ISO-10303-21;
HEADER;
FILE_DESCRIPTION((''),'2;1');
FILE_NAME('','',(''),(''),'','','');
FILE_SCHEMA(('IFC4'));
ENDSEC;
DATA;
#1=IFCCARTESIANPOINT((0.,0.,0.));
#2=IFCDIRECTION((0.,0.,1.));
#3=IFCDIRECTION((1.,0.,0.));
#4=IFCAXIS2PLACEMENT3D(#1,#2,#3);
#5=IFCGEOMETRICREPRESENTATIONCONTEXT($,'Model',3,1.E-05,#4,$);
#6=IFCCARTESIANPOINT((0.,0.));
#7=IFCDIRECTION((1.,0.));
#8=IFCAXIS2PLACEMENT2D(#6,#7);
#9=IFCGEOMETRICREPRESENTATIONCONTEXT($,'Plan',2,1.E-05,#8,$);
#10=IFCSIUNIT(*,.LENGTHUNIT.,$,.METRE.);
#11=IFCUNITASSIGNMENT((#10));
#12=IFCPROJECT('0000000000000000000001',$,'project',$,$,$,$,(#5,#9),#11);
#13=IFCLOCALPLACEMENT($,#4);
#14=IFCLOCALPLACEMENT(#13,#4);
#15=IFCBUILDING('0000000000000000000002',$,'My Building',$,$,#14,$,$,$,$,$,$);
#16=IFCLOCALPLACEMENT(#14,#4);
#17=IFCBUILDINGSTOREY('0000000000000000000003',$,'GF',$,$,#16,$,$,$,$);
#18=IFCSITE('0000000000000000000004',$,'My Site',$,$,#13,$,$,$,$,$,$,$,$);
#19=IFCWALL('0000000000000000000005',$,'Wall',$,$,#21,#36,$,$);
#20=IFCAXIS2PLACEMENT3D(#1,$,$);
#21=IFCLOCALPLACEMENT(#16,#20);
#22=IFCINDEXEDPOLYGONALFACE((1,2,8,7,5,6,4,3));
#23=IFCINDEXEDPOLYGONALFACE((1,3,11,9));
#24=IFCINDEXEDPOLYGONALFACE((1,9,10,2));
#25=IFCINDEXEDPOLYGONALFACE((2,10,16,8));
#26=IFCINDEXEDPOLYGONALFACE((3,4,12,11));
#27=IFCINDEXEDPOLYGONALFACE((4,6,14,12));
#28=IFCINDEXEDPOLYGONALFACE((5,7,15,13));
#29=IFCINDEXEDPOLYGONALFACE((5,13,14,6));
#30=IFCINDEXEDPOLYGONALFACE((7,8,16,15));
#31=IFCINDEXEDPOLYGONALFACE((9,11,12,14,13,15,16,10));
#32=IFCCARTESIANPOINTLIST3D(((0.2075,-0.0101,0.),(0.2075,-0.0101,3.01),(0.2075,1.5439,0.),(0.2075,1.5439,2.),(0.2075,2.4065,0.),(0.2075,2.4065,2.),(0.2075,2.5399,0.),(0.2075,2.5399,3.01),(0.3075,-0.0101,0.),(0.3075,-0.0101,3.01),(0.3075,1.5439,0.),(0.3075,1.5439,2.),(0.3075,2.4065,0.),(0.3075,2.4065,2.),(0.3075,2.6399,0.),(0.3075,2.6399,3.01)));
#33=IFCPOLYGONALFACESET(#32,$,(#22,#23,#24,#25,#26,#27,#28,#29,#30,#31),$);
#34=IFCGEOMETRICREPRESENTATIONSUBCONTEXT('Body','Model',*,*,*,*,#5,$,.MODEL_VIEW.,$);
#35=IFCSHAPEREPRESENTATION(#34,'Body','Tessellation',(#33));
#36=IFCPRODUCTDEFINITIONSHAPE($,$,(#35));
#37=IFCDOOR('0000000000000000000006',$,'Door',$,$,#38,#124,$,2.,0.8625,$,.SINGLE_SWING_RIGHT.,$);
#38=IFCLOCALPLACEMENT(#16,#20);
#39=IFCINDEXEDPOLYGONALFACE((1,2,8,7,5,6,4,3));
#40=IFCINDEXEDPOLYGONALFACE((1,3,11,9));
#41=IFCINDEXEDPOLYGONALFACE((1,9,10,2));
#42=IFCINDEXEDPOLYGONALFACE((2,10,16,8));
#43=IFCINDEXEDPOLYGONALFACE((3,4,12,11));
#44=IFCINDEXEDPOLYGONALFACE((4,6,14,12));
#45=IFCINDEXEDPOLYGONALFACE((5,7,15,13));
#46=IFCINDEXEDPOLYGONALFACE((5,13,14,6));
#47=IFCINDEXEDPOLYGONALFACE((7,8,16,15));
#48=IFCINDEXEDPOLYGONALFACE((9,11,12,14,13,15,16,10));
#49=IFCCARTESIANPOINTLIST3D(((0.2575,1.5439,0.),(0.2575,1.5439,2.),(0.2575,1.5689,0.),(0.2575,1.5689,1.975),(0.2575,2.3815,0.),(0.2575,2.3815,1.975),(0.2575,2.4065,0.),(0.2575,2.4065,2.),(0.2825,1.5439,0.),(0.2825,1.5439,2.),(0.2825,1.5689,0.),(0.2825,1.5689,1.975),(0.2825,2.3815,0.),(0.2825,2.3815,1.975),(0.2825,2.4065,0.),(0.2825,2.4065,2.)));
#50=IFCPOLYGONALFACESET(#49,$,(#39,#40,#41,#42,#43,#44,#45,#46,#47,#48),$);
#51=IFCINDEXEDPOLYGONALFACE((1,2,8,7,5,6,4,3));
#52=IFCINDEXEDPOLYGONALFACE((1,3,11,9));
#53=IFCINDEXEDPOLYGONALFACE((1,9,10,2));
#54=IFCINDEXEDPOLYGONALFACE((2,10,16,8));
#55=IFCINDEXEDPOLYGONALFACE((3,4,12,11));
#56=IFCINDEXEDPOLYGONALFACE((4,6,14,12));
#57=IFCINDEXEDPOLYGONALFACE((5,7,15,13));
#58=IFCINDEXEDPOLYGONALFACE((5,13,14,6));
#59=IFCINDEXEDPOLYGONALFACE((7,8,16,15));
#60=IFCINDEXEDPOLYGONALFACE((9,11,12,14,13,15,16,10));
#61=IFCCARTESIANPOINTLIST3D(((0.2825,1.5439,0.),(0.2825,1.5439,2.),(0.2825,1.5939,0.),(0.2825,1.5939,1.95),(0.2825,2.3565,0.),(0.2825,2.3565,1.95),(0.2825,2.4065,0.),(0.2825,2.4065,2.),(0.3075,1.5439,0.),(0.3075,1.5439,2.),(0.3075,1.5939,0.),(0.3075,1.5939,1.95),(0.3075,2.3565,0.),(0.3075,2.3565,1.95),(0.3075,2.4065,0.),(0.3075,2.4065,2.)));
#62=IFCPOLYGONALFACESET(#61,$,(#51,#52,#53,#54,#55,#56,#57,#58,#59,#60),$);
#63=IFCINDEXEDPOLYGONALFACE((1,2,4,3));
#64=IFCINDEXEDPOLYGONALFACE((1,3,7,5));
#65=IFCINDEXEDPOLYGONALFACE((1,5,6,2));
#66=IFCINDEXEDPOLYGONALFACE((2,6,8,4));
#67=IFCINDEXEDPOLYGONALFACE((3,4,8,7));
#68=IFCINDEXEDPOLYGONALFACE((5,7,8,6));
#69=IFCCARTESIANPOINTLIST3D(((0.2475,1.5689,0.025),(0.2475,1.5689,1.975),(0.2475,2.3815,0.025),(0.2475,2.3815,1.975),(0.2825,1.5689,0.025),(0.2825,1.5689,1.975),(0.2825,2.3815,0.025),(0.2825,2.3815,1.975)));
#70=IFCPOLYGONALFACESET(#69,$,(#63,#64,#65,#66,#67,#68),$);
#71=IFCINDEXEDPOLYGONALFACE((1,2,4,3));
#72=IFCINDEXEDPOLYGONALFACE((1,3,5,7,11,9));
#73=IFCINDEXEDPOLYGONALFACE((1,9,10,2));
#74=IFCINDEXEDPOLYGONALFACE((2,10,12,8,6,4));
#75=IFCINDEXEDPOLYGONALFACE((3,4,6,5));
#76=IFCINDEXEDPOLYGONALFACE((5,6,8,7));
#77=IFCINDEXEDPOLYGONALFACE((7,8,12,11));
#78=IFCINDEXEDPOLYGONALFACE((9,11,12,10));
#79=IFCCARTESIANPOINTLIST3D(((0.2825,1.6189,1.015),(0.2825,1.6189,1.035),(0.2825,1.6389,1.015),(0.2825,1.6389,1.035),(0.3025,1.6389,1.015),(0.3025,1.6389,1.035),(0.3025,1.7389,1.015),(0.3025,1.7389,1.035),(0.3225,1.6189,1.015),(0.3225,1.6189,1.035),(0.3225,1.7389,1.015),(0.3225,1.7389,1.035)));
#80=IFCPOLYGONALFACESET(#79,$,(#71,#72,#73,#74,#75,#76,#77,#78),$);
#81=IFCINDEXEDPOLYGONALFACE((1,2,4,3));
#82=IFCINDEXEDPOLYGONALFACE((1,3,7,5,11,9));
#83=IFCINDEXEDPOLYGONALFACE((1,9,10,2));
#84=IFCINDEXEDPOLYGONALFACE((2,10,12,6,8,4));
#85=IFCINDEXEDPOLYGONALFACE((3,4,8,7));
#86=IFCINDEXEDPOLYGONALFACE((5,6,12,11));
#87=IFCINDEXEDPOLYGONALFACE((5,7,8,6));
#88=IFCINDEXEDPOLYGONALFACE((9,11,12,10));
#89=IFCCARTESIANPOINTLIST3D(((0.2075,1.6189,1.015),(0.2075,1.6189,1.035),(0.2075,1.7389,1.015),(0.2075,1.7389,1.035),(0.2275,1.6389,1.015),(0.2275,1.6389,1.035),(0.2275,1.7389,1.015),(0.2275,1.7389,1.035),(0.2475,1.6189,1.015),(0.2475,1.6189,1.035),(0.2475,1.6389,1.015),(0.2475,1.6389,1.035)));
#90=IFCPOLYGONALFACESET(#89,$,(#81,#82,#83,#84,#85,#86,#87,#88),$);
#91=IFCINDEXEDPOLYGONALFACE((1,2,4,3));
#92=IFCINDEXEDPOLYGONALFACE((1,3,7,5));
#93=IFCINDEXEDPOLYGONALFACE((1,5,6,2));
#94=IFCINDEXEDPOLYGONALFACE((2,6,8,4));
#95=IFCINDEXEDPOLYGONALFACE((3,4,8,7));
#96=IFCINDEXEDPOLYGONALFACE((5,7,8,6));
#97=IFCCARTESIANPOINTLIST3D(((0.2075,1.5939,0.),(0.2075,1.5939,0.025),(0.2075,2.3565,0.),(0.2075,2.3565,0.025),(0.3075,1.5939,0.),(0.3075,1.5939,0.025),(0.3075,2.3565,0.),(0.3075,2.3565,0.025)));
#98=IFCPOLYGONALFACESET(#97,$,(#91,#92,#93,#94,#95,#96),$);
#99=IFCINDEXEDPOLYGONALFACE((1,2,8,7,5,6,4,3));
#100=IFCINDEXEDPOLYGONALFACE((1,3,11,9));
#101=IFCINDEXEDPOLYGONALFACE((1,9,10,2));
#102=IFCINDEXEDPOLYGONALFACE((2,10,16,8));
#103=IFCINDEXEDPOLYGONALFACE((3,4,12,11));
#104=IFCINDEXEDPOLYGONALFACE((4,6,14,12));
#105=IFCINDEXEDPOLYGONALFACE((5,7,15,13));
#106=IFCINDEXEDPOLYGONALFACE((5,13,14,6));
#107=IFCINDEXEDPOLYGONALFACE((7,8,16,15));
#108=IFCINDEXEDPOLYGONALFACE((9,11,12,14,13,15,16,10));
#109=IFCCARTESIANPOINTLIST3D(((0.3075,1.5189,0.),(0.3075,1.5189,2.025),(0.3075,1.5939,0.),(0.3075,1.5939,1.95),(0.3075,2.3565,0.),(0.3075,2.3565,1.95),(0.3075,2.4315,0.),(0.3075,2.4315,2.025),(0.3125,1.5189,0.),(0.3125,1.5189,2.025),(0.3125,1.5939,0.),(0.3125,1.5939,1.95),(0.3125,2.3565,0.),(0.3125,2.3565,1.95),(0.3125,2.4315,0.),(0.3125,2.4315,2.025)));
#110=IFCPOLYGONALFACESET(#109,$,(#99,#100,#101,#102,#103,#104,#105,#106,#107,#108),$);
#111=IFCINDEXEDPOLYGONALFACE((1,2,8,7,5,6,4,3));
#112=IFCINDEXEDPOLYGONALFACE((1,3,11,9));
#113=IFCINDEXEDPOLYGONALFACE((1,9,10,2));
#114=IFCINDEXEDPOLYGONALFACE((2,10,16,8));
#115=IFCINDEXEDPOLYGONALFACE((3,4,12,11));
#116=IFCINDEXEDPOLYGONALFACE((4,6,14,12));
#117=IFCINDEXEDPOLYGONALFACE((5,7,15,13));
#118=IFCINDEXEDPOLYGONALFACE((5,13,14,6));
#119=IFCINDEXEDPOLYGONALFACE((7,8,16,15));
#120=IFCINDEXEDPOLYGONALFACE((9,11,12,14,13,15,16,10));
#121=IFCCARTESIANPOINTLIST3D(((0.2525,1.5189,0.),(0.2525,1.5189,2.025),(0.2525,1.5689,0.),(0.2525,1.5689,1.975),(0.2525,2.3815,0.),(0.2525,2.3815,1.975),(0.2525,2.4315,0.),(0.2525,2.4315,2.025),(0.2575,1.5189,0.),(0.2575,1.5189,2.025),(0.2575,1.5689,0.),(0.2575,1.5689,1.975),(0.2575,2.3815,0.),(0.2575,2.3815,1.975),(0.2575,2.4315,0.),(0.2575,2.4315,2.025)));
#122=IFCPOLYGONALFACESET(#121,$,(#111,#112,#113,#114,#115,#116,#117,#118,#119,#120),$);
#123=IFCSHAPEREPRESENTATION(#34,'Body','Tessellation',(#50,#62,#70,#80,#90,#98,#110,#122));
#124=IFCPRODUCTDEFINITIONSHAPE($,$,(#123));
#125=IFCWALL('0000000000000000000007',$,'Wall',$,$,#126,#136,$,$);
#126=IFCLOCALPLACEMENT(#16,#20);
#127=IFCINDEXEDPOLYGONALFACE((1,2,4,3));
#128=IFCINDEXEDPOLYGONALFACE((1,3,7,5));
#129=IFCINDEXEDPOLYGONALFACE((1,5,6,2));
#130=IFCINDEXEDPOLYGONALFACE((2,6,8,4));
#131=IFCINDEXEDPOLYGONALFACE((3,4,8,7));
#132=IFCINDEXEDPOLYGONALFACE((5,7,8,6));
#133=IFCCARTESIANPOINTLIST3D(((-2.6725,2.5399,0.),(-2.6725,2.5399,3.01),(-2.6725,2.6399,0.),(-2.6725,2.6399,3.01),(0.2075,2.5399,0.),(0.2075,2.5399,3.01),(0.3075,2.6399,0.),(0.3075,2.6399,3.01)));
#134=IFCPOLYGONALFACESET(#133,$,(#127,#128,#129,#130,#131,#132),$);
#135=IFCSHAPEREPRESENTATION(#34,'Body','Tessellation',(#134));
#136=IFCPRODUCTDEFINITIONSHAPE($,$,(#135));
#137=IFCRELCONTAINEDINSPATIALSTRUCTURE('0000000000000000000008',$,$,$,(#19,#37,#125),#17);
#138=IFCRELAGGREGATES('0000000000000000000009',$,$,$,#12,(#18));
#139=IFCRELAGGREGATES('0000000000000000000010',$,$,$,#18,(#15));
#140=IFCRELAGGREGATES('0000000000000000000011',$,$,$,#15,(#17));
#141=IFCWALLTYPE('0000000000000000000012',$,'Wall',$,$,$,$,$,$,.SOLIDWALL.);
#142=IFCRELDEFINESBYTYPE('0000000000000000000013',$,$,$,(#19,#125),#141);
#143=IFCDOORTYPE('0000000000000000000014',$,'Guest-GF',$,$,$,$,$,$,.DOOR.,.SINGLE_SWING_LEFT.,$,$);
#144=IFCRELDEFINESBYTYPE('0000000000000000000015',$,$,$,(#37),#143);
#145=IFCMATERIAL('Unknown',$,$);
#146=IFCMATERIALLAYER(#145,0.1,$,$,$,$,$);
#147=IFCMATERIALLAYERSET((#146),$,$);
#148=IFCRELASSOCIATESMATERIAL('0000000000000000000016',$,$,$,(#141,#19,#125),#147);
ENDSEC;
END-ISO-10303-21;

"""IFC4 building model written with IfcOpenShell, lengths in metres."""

from ifc_helpers import new_model, entity, si_unit, frame, origin_with_axes, origin_2d_with_axis, place, context, subcontext, project, spatial, line, indexed_curve, outline, extrude, shape, source, transform, mapped, material, layer, layer_set, layer_usage, type_object, type_shapes, element, fill, save


model = new_model("IFC4")

# Units and contexts
model_context = context("Model", 3, precision=1e-05, world=origin_with_axes())
plan_context = context("Plan", 2, precision=1e-05, world=origin_2d_with_axis())
body_context_1 = subcontext(model_context, "Body", "Model", "MODEL_VIEW")
body_context_2 = subcontext(plan_context, "Body", "Plan", "PLAN_VIEW")
ifc_project = project(units=[si_unit("LENGTHUNIT", "METRE")], contexts=[model_context, plan_context])

# Site, building, storey
site_placement = place(None, origin_with_axes())
site = spatial("IfcSite", under=ifc_project, at=site_placement, Name="My Site")
building_placement = place(site_placement, origin_with_axes())
building = spatial("IfcBuilding", under=site, at=building_placement, Name="My Building")
storey_placement = place(building_placement, origin_with_axes())
storey = spatial("IfcBuildingStorey", under=building, at=storey_placement, Name="GF")

# Shared definitions
ifc_material_1 = material(Name="Unknown")

# Shared definitions
ifc_layer_1 = layer(ifc_material_1, 0.1)
ifc_layer_set_1 = layer_set([ifc_layer_1])
wall_type = type_object("IfcWallType", Name="Wall", PredefinedType="SOLIDWALL", material=ifc_layer_set_1)

# Wall, opening, door
ifc_layer_usage_1 = layer_usage(ifc_layer_set_1, "AXIS2", "POSITIVE", 0.0)
wall_1_placement = place(storey_placement, frame((0.3075, -0.0101, 0.0), z_axis=(0.0, 0.0, 1.0), x_axis=(0.0, 1.0, 0.0)))
wall_1 = element("IfcWall", 1, at=wall_1_placement, inside=storey, type_object=wall_type, material=ifc_layer_usage_1, Name="Wall", context=body_context_1, shape_type="SweptSolid", body=[
    extrude(outline(indexed_curve([(0.0, 0.0), (0.0, 0.1), (2.55, 0.1), (2.65, 0.0)], segments=[line(1, 2, 3, 4, 1)])), origin_with_axes(), (0.0, 0.0, 1.0), 3.01),
])
shared_shape_1 = source(origin_with_axes(), body_context_1, "Body", "SweptSolid", [
    extrude(outline(indexed_curve([(0.0, 0.0), (0.8625, 0.0), (0.8625, 2.0), (0.0, 2.0)], segments=[line(1, 2, 3, 4, 1)])), frame((0.0, -0.6, 0.0), z_axis=(0.0, -1.0, 0.0), x_axis=(1.0, 0.0, 0.0)), (0.0, 0.0, -1.0), 1.2),
])
opening_1_placement = place(wall_1_placement, frame((1.554, 0.0, 0.0), z_axis=(0.0, 0.0, 1.0), x_axis=(1.0, 0.0, 0.0)))
opening_1 = element("IfcOpeningElement", 2, at=opening_1_placement, cuts=wall_1, PredefinedType="OPENING", context=body_context_1, shape_type="MappedRepresentation", body=[
    mapped(shared_shape_1, transform((0.0, 0.0, 0.0), x_axis=(1.0, 0.0, 0.0), y_axis=(0.0, 1.0, 0.0), z_axis=(0.0, 0.0, 1.0), scale=1.0)),
])
door_type_1 = type_object("IfcDoorType", Name="Guest-GF", OperationType="SINGLE_SWING_LEFT", PredefinedType="DOOR")
shared_shape_2 = source(origin_with_axes(), body_context_1, "Body", "SweptSolid", [
    extrude(outline(indexed_curve([(0.0, 0.0), (0.0, 2.0), (0.8625, 2.0), (0.8625, 0.0), (0.8375, 0.0), (0.8375, 1.975), (0.025, 1.975), (0.025, 0.0)], segments=[line(1, 2, 3, 4, 5, 6, 7, 8, 1)])), frame((0.0, 0.025, 0.0), z_axis=(0.0, -1.0, 0.0), x_axis=(1.0, 0.0, 0.0)), (0.0, 0.0, -1.0), 0.025),
    extrude(outline(indexed_curve([(0.0, 0.0), (0.0, 2.0), (0.8625, 2.0), (0.8625, 0.0), (0.8125, 0.0), (0.8125, 1.95), (0.05, 1.95), (0.05, 0.0)], segments=[line(1, 2, 3, 4, 5, 6, 7, 8, 1)])), frame((0.0, 0.0, 0.0), z_axis=(0.0, -1.0, 0.0), x_axis=(1.0, 0.0, 0.0)), (0.0, 0.0, -1.0), 0.025),
    extrude(outline(indexed_curve([(0.0, 0.0), (0.8125, 0.0), (0.8125, 0.035), (0.0, 0.035)], segments=[line(1, 2, 3, 4, 1)])), frame((0.025, 0.025, 0.025), z_axis=(0.0, 0.0, 1.0), x_axis=(1.0, 0.0, 0.0)), (0.0, 0.0, 1.0), 1.95),
    extrude(outline(indexed_curve([(0.0, 0.0), (0.0, -0.04), (0.12, -0.04), (0.12, -0.02), (0.02, -0.02), (0.02, 0.0)], segments=[line(1, 2, 3, 4, 5, 6, 1)])), frame((0.075, 0.025, 1.015), z_axis=(0.0, 0.0, 1.0), x_axis=(1.0, 0.0, 0.0)), (0.0, 0.0, 1.0), 0.02),
    extrude(outline(indexed_curve([(0.0, 0.0), (0.0, 0.04), (0.12, 0.04), (0.12, 0.02), (0.02, 0.02), (0.02, 0.0)], segments=[line(1, 2, 3, 4, 5, 6, 1)])), frame((0.075, 0.06, 1.015), z_axis=(0.0, 0.0, 1.0), x_axis=(1.0, 0.0, 0.0)), (0.0, 0.0, 1.0), 0.02),
    extrude(outline(indexed_curve([(0.0, 0.0), (0.7625, 0.0), (0.7625, 0.1), (0.0, 0.1)], segments=[line(1, 2, 3, 4, 1)])), frame((0.05, 0.0, 0.0), z_axis=(0.0, 0.0, 1.0), x_axis=(1.0, 0.0, 0.0)), (0.0, 0.0, 1.0), 0.025),
    extrude(outline(indexed_curve([(0.0, 0.0), (0.0, 2.025), (0.9125, 2.025), (0.9125, 0.0), (0.8375, 0.0), (0.8375, 1.95), (0.075, 1.95), (0.075, 0.0)], segments=[line(1, 2, 3, 4, 5, 6, 7, 8, 1)])), frame((-0.025, -0.005, 0.0), z_axis=(0.0, -1.0, 0.0), x_axis=(1.0, 0.0, 0.0)), (0.0, 0.0, -1.0), 0.005),
    extrude(outline(indexed_curve([(0.0, 0.0), (0.0, 2.025), (0.9125, 2.025), (0.9125, 0.0), (0.8625, 0.0), (0.8625, 1.975), (0.05, 1.975), (0.05, 0.0)], segments=[line(1, 2, 3, 4, 5, 6, 7, 8, 1)])), frame((-0.025, 0.05, 0.0), z_axis=(0.0, -1.0, 0.0), x_axis=(1.0, 0.0, 0.0)), (0.0, 0.0, -1.0), 0.005),
])
shared_shape_3 = source(origin_with_axes(), body_context_2, "Body", "Curve2D", [
    entity("IfcIndexedPolyCurve", entity("IfcCartesianPointList2D", [[0.0, 0.0], [0.0, 0.05], [0.025, 0.05], [0.025, 0.025], [0.05, 0.025], [0.05, 0.0]]), [entity("IfcLineIndex", [1, 2, 3, 4, 5, 6, 1])]),
    entity("IfcIndexedPolyCurve", entity("IfcCartesianPointList2D", [[0.8625, 0.0], [0.8625, 0.05], [0.8375, 0.05], [0.8375, 0.025], [0.8125, 0.025], [0.8125, 0.0]]), [entity("IfcLineIndex", [1, 2, 3, 4, 5, 6, 1])]),
    entity("IfcTrimmedCurve", entity("IfcEllipse", entity("IfcAxis2Placement2D", entity("IfcCartesianPoint", [0.8025, 0.05]), entity("IfcDirection", [1.0, 0.0])), 0.7775, 0.8125), [entity("IfcCartesianPoint", [0.8025, 0.8625])], [entity("IfcCartesianPoint", [0.025, 0.05])], True, "CARTESIAN"),
    entity("IfcIndexedPolyCurve", entity("IfcCartesianPointList2D", [[0.8375, 0.05], [0.8025, 0.05], [0.8025, 0.8625], [0.8375, 0.8625]]), [entity("IfcLineIndex", [1, 2, 3, 4, 1])]),
])
type_shapes(door_type_1, [shared_shape_2, shared_shape_3])
door_1_placement = place(opening_1_placement, frame((0.0, 0.0, 0.0), z_axis=(0.0, 0.0, 1.0), x_axis=(1.0, 0.0, 0.0)))
door_1 = element("IfcDoor", 3, at=door_1_placement, inside=storey, type_object=door_type_1, Name="Door", OperationType="SINGLE_SWING_RIGHT", OverallHeight=2.0, OverallWidth=0.8625, shapes=[
    shape(body_context_1, "Body", "MappedRepresentation", [mapped(shared_shape_2, transform((0.0, 0.0, 0.0), x_axis=(1.0, 0.0, 0.0), y_axis=(0.0, 1.0, 0.0), z_axis=(0.0, 0.0, 1.0), scale=1.0))]),
    shape(body_context_2, "Body", "MappedRepresentation", [mapped(shared_shape_3, transform((0.0, 0.0, 0.0), x_axis=(1.0, 0.0, 0.0), y_axis=(0.0, 1.0, 0.0), z_axis=(0.0, 0.0, 1.0), scale=1.0))]),
])
fill(opening_1, door_1)

# Wall
ifc_layer_usage_2 = layer_usage(ifc_layer_set_1, "AXIS2", "POSITIVE", 0.0)
wall_2_placement = place(storey_placement, frame((0.3075, 2.6399, 0.0), z_axis=(0.0, 0.0, 1.0), x_axis=(-1.0, 0.0, 0.0)))
element("IfcWall", 4, at=wall_2_placement, inside=storey, type_object=wall_type, material=ifc_layer_usage_2, Name="Wall", context=body_context_1, shape_type="SweptSolid", body=[
    extrude(outline(indexed_curve([(0.0, 0.0), (0.1, 0.1), (2.98, 0.1), (2.98, 0.0)], segments=[line(1, 2, 3, 4, 1)])), origin_with_axes(), (0.0, 0.0, 1.0), 3.01),
])

save(model, "model.ifc")
